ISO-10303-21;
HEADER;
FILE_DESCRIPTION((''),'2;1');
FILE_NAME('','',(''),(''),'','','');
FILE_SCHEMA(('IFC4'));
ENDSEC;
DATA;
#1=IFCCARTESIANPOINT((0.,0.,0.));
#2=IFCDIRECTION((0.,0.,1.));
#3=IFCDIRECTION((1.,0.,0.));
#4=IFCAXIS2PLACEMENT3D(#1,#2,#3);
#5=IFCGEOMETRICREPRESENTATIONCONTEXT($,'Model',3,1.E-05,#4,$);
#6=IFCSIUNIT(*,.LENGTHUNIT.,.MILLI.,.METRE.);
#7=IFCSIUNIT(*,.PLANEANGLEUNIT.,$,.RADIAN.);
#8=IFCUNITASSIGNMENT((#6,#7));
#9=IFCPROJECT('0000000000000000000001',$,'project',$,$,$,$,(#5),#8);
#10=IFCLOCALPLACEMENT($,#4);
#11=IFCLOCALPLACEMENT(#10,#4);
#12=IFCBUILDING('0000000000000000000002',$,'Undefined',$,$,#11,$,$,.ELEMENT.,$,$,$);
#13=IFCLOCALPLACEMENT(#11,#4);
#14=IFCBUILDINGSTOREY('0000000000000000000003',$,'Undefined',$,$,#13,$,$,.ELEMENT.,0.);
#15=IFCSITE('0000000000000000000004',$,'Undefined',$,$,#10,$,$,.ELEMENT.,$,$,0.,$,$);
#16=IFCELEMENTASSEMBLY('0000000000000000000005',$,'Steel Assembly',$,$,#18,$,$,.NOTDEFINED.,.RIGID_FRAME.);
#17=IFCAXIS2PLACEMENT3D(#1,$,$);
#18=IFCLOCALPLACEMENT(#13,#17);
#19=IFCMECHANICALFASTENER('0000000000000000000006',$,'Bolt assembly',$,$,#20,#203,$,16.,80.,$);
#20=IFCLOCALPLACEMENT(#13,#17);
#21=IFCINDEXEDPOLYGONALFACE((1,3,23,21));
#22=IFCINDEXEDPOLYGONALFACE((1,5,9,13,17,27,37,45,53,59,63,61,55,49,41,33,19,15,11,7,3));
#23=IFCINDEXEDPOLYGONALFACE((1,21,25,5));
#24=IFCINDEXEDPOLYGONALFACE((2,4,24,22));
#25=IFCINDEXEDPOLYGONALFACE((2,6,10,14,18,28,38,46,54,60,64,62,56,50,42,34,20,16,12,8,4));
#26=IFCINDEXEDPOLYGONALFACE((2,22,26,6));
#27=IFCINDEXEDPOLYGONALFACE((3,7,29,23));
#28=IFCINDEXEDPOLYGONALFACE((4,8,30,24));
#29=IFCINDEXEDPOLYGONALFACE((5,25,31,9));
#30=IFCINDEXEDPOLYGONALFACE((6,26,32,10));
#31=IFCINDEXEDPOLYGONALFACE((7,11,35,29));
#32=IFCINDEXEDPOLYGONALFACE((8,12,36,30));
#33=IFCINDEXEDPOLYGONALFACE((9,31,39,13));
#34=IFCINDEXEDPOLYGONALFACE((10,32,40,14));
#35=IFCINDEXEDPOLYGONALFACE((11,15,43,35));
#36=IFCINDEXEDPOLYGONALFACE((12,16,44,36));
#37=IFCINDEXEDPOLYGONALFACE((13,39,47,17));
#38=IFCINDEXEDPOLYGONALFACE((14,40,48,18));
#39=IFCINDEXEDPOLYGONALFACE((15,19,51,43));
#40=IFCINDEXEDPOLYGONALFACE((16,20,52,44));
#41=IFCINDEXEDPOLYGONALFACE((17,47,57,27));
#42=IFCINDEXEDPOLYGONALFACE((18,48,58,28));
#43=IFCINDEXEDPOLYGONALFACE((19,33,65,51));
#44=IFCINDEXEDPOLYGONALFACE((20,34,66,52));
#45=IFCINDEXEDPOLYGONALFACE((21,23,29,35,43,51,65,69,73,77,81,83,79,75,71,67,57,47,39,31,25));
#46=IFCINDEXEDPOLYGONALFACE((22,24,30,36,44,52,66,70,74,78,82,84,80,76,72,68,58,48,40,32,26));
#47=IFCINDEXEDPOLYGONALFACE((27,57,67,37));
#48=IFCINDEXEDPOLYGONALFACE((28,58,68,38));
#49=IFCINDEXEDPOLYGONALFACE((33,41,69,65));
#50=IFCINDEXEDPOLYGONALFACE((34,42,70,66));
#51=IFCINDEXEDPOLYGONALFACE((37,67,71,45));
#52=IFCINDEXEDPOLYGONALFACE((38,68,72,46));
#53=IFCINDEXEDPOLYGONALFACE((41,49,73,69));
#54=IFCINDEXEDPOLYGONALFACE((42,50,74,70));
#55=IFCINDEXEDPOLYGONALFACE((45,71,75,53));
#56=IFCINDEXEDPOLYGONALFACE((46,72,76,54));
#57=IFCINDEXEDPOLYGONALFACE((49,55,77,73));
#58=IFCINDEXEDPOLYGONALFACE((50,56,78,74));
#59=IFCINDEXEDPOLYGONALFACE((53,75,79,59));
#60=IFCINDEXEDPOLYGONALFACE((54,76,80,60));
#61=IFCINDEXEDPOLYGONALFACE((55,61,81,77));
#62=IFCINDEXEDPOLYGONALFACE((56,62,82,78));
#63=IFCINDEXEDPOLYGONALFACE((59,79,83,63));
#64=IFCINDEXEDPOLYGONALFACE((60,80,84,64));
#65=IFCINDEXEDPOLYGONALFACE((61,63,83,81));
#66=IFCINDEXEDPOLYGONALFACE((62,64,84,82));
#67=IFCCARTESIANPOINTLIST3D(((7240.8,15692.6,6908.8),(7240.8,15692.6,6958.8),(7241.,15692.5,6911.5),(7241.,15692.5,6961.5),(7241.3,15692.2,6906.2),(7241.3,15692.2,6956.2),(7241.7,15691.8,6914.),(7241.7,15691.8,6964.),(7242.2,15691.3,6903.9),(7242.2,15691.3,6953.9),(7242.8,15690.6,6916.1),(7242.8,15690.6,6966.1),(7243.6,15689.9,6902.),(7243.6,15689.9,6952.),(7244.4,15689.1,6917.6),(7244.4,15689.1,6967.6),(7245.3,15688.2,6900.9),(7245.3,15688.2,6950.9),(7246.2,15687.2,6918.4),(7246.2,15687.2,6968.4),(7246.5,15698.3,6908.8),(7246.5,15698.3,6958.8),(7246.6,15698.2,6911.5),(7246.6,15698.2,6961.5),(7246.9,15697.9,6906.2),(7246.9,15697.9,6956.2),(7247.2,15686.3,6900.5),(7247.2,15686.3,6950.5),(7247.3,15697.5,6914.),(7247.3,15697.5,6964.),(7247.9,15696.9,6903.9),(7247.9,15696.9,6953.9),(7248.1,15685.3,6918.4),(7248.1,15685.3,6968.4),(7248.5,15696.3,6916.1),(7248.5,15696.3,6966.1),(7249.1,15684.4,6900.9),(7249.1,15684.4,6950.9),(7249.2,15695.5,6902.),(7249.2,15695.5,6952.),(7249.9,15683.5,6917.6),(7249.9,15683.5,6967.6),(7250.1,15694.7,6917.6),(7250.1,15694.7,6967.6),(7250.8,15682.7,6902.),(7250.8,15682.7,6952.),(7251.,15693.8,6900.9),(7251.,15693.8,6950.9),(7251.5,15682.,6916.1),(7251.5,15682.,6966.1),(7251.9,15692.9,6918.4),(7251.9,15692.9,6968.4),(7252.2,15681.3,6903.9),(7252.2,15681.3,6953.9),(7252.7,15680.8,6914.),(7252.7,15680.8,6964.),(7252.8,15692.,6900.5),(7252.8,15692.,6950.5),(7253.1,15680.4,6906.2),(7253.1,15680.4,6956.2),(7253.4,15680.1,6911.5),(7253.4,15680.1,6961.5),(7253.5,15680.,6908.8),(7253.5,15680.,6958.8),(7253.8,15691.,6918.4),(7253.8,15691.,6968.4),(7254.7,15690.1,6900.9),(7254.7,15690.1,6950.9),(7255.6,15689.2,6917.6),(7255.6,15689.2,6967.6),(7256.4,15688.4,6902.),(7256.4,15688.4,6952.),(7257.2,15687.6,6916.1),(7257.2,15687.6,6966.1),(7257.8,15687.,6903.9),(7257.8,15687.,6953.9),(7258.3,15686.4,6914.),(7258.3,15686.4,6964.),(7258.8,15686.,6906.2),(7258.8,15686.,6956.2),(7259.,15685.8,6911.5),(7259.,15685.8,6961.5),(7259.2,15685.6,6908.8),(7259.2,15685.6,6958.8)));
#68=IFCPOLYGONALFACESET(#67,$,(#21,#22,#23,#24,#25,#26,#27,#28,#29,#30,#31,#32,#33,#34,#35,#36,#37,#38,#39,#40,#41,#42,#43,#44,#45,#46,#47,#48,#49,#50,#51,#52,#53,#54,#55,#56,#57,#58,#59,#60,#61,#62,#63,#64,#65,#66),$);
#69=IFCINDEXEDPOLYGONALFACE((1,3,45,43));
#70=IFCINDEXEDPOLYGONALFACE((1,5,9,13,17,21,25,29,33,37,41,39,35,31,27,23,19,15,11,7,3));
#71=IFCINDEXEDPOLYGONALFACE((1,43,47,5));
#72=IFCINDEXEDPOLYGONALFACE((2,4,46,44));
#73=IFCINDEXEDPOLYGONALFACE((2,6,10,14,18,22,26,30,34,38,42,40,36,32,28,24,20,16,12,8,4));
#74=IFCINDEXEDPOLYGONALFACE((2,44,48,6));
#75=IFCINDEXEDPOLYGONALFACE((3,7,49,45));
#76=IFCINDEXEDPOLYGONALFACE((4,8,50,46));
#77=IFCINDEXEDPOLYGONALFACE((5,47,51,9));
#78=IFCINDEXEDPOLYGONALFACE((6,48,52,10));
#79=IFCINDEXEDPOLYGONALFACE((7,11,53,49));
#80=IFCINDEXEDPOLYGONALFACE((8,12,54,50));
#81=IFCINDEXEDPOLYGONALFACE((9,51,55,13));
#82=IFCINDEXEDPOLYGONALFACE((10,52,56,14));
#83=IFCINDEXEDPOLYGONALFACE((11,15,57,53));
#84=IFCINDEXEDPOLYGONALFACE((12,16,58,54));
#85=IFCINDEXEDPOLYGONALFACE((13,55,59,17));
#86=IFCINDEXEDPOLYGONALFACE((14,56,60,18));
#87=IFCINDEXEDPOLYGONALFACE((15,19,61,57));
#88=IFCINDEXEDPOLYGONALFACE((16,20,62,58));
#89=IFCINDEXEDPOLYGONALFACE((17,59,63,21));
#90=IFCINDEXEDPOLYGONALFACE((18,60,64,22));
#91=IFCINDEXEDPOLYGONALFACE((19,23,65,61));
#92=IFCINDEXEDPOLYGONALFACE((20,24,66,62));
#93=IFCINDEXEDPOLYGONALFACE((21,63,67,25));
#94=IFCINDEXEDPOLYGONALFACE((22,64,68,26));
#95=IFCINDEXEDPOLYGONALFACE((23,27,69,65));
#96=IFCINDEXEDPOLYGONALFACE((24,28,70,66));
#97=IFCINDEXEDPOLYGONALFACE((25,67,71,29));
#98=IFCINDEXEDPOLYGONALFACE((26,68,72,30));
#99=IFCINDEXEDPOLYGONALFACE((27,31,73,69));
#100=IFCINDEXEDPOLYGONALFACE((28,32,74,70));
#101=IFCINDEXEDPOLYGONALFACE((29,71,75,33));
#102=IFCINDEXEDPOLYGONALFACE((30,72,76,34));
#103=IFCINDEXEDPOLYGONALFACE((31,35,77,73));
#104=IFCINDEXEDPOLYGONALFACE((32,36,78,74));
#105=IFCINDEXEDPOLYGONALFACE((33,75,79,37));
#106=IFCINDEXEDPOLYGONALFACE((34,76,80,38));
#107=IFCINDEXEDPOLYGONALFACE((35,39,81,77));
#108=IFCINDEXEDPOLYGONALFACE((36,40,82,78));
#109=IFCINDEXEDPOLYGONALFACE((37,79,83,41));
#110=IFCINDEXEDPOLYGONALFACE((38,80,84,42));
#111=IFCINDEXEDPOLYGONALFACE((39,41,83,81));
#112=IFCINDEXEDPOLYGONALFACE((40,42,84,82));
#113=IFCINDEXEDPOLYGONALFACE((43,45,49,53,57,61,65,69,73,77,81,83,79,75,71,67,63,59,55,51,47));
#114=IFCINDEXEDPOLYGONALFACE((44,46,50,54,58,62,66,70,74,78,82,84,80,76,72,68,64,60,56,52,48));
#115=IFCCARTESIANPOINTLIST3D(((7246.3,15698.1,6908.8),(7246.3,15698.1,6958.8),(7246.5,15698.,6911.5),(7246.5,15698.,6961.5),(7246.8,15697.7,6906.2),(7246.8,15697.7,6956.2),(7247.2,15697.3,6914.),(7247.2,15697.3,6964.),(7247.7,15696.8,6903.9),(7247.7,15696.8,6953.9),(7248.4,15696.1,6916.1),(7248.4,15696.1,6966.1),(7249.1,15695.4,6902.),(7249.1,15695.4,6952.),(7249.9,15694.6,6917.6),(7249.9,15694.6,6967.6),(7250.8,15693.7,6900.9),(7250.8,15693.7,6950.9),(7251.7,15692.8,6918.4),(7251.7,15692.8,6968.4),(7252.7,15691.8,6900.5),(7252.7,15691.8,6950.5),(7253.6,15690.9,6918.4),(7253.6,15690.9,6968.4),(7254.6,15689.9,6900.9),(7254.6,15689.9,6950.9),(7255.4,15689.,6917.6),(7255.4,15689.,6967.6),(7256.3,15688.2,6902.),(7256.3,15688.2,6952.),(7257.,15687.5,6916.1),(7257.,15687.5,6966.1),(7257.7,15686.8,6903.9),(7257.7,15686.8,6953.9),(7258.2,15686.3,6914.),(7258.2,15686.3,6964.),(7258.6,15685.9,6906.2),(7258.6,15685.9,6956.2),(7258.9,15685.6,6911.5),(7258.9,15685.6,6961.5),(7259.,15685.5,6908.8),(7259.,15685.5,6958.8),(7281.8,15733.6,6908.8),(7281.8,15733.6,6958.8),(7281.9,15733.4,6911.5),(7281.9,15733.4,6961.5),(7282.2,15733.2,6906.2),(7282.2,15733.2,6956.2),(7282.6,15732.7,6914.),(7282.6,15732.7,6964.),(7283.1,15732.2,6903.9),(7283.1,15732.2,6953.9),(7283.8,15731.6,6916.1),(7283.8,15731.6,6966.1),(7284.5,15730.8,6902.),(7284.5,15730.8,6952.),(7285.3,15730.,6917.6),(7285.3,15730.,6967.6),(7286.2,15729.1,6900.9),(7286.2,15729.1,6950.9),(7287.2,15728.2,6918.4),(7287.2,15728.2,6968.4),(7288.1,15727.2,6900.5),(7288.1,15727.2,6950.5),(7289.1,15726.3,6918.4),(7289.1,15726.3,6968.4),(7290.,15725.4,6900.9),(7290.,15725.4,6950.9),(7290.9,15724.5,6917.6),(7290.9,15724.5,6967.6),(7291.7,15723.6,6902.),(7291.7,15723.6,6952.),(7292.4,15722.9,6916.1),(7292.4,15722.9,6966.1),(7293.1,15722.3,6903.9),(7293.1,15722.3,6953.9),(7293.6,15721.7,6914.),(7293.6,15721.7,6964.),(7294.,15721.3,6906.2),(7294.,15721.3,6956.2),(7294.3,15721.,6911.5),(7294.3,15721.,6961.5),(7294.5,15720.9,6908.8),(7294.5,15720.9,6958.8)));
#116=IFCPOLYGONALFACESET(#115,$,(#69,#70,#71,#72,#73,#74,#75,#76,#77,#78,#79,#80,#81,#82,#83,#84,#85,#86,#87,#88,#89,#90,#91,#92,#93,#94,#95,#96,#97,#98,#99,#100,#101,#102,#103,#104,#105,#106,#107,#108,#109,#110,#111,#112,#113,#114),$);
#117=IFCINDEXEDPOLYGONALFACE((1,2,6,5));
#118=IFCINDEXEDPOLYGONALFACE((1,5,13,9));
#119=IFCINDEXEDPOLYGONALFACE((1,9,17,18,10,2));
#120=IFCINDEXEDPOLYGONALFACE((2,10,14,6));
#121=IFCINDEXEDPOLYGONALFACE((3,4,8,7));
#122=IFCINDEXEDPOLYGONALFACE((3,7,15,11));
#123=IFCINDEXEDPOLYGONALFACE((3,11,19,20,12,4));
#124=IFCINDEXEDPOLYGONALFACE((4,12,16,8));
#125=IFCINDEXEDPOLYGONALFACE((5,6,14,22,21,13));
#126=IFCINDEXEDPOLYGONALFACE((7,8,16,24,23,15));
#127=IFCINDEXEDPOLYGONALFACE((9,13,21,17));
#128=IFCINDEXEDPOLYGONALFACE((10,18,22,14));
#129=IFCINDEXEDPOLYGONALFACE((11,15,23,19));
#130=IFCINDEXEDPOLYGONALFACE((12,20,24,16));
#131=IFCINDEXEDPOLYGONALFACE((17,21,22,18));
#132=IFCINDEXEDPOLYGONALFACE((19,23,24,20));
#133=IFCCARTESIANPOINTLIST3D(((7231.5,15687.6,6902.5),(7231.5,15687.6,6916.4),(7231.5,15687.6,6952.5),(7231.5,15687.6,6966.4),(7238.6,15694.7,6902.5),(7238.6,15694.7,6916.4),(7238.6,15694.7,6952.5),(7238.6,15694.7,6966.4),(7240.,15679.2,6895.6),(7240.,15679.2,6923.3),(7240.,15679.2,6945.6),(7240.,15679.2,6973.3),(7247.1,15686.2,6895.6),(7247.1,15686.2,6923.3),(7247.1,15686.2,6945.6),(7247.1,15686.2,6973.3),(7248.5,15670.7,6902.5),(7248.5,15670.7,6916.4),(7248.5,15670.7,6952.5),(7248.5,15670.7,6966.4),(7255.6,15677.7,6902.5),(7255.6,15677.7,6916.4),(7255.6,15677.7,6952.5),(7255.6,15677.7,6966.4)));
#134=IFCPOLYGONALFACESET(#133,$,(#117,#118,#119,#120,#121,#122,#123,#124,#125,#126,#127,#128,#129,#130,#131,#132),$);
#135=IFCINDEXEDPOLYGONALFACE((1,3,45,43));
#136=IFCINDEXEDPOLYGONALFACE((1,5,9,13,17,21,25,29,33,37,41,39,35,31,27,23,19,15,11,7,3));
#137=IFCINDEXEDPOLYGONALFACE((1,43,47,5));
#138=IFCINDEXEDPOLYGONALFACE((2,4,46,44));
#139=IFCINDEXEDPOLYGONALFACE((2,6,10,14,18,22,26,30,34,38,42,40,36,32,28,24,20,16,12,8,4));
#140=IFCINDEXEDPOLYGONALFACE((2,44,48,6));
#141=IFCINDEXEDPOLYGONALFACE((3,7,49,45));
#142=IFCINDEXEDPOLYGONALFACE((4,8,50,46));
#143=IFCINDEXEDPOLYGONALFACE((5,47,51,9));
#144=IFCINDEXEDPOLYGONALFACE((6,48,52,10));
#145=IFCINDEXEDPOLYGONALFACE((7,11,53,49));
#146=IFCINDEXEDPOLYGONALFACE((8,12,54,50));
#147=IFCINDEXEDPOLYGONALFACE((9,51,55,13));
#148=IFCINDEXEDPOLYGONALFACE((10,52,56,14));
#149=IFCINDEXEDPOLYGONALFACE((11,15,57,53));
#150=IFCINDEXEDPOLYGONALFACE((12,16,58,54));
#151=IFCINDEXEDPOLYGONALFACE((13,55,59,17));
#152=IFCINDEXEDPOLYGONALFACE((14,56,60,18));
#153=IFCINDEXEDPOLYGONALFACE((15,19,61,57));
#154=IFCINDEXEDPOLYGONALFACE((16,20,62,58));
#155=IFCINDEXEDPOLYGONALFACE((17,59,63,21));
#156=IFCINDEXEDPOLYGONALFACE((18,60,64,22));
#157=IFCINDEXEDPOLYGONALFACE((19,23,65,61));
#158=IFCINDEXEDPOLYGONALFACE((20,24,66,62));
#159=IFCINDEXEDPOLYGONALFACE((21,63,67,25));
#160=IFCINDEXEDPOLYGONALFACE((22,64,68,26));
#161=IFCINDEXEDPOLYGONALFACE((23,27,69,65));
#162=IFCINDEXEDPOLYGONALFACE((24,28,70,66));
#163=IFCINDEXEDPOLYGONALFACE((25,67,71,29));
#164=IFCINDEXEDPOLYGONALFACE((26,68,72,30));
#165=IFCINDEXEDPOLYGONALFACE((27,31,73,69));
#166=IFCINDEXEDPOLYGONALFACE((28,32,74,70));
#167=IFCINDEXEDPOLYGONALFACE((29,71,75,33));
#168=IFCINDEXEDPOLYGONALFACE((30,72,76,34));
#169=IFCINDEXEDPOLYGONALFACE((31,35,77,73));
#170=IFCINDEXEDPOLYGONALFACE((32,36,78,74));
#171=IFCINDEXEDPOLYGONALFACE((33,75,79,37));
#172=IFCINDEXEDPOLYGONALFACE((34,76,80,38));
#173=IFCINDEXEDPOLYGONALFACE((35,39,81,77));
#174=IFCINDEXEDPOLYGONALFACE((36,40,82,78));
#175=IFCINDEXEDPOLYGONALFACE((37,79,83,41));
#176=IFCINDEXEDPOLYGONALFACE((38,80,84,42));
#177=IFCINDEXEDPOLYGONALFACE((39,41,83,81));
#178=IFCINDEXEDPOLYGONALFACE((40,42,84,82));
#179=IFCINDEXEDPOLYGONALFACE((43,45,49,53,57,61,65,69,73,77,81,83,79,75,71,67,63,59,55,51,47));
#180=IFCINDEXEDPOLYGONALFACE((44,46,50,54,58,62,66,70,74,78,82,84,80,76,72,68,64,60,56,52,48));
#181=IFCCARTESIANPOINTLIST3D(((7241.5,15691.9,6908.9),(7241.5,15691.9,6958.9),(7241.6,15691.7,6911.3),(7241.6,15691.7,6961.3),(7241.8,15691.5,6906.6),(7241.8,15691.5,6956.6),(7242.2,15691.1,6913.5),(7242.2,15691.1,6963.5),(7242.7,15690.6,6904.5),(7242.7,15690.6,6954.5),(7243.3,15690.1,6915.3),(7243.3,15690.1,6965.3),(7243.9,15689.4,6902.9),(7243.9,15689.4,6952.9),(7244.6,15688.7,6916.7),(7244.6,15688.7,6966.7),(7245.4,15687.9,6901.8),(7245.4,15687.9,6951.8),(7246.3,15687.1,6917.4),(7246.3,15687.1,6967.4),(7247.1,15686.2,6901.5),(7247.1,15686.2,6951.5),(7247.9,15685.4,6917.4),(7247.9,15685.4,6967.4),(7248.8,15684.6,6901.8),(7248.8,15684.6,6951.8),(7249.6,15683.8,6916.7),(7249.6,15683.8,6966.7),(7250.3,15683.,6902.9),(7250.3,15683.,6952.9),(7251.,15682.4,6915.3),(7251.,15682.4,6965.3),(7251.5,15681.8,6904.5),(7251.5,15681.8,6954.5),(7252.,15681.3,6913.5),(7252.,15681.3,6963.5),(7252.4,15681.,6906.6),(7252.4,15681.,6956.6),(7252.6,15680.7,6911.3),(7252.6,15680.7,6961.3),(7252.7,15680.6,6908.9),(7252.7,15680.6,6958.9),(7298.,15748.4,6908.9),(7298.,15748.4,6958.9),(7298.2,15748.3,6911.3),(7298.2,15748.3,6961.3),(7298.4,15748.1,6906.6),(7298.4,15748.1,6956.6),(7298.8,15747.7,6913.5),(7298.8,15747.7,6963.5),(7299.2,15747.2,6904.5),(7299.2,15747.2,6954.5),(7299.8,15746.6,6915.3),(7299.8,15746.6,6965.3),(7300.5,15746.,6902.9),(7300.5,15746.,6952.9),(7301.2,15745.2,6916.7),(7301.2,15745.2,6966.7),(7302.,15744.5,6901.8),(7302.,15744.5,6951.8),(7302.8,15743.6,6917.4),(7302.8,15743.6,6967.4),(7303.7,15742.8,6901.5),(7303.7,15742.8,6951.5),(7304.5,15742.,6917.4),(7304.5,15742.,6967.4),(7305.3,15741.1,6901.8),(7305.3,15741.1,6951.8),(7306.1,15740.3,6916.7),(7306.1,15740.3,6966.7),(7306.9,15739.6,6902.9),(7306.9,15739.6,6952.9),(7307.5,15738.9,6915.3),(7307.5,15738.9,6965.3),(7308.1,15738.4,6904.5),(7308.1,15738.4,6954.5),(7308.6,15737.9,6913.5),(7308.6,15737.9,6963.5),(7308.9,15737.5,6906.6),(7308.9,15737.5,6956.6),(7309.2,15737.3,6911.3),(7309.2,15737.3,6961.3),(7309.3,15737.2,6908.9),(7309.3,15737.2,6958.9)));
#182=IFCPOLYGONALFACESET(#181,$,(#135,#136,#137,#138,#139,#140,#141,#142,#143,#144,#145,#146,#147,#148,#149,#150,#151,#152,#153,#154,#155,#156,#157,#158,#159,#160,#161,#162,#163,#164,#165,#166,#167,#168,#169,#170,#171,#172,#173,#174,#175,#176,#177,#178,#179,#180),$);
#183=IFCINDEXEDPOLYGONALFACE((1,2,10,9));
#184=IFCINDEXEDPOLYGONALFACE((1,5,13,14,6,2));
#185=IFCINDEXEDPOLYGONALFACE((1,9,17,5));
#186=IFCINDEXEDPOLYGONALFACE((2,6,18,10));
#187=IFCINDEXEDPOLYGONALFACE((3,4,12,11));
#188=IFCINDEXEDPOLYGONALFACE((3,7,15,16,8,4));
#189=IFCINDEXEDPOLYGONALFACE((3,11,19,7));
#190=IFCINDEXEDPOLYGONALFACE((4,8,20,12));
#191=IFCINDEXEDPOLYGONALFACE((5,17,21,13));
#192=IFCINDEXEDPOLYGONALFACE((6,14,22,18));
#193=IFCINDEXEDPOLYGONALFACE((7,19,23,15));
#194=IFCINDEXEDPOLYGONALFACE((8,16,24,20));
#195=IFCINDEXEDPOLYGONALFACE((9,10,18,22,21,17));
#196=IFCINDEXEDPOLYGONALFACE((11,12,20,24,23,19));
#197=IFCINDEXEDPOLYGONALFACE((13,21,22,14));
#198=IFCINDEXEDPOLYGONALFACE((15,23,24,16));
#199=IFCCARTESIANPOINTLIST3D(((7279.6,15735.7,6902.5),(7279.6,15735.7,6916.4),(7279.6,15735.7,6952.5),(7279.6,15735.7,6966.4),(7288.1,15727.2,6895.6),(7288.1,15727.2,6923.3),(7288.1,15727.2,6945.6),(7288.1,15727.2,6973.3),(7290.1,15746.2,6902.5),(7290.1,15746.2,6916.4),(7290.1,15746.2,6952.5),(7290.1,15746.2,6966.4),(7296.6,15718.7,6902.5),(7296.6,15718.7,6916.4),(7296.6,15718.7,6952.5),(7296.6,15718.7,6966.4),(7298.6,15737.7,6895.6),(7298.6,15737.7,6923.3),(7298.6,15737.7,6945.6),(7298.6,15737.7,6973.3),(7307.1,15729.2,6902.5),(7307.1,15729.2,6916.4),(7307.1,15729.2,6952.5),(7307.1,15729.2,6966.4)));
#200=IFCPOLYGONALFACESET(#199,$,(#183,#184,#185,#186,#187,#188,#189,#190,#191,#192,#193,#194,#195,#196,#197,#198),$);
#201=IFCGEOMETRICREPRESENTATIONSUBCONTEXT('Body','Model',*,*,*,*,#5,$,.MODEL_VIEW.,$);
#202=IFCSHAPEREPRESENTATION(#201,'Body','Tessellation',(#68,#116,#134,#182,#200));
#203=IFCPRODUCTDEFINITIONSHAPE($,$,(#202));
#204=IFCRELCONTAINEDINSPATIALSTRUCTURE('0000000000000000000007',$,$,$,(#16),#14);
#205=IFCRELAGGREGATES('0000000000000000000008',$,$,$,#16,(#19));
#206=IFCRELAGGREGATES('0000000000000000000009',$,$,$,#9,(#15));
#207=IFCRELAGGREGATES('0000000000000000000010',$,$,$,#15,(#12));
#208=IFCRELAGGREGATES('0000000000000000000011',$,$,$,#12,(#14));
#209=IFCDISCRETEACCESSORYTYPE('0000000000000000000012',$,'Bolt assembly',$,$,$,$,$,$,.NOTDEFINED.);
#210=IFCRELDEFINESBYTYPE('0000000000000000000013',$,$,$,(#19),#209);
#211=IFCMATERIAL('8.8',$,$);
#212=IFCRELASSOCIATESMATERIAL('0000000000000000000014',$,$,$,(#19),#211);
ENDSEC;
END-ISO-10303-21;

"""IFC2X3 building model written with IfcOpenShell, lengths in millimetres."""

from ifc_helpers import new_model, si_unit, frame, origin_with_axes, origin_2d_with_axis, place, context, subcontext, project, spatial, polyline, circle, outline, extrude, source, transform, mapped, material, type_object, element, aggregate, save


model = new_model("IFC2X3")

# Units and contexts
model_context = context("Model", 3, precision=1e-05, world=origin_with_axes())
body_context = subcontext(model_context, "Body", "Model", "MODEL_VIEW")
ifc_project = project(units=[si_unit("LENGTHUNIT", "METRE", prefix="MILLI"), si_unit("PLANEANGLEUNIT", "RADIAN")], contexts=[model_context])

# Site, building, storey
site_placement = place(None, origin_with_axes())
site = spatial("IfcSite", under=ifc_project, at=site_placement, Name="Undefined", CompositionType="ELEMENT", RefElevation=0.0)
building_placement = place(site_placement, origin_with_axes())
building = spatial("IfcBuilding", under=site, at=building_placement, Name="Undefined", CompositionType="ELEMENT")
storey_placement = place(building_placement, origin_with_axes())
storey = spatial("IfcBuildingStorey", under=building, at=storey_placement, Name="Undefined", CompositionType="ELEMENT", Elevation=0.0)

# Element assembly
assembly_1_placement = place(storey_placement, origin_with_axes())
assembly_1 = element("IfcElementAssembly", 1, at=assembly_1_placement, inside=storey, Name="Steel Assembly", AssemblyPlace="NOTDEFINED", PredefinedType="RIGID_FRAME")

# Shared definitions
ifc_material_1 = material(Name="8.8")
discrete_accessory_type_1 = type_object("IfcDiscreteAccessoryType", Name="Bolt assembly")

# Mechanical fastener
shared_shape_1 = source(origin_with_axes(), body_context, "Body", "SweptSolid", [
    extrude(circle(Radius=9.0, at=origin_2d_with_axis()), frame((0.0, 0.1, 0.0), z_axis=(0.0, 1.0, 0.0), x_axis=(1.0, 0.0, 0.0)), (0.0, 0.0, 1.0), 8.0),
    extrude(circle(Radius=9.0, at=origin_2d_with_axis()), frame((0.0, 7.9, 0.0), z_axis=(0.0, 1.0, 0.0), x_axis=(1.0, 0.0, 0.0)), (0.0, 0.0, 1.0), 50.1),
    extrude(outline(polyline([(13.9, 0.0), (6.9, 12.0), (-6.9, 12.0), (-13.9, 0.0), (-6.9, -12.0), (6.9, -12.0), (13.9, 0.0)])), frame((0.0, -10.0, 0.0), z_axis=(0.0, 1.0, 0.0), x_axis=(1.0, 0.0, 0.0)), (0.0, 0.0, 1.0), 10.0),
    extrude(circle(Radius=8.0, at=origin_2d_with_axis()), frame((0.0, 0.0, 0.0), z_axis=(0.0, 1.0, 0.0), x_axis=(1.0, 0.0, 0.0)), (0.0, 0.0, 1.0), 80.0),
    extrude(outline(polyline([(13.9, 0.0), (6.9, 12.0), (-6.9, 12.0), (-13.9, 0.0), (-6.9, -12.0), (6.9, -12.0), (13.9, 0.0)])), frame((0.0, 58.0, 0.0), z_axis=(0.0, 1.0, 0.0), x_axis=(1.0, 0.0, 0.0)), (0.0, 0.0, 1.0), 14.8),
])
mechanical_fastener_1_placement = place(assembly_1_placement, frame((7247.1, 15686.2, 6959.5), z_axis=(0.707107, -0.707107, 0.0), x_axis=(0.0, 0.0, -1.0)))
mechanical_fastener_1 = element("IfcMechanicalFastener", 2, at=mechanical_fastener_1_placement, type_object=discrete_accessory_type_1, material=ifc_material_1, Name="Bolt assembly", NominalDiameter=16.0, NominalLength=80.0, context=body_context, shape_type="MappedRepresentation", body=[
    mapped(shared_shape_1, transform((0.0, 0.0, 0.0))),
    mapped(shared_shape_1, transform((50.0, 0.0, 0.0))),
])
aggregate(assembly_1, [mechanical_fastener_1])

save(model, "model.ifc")
